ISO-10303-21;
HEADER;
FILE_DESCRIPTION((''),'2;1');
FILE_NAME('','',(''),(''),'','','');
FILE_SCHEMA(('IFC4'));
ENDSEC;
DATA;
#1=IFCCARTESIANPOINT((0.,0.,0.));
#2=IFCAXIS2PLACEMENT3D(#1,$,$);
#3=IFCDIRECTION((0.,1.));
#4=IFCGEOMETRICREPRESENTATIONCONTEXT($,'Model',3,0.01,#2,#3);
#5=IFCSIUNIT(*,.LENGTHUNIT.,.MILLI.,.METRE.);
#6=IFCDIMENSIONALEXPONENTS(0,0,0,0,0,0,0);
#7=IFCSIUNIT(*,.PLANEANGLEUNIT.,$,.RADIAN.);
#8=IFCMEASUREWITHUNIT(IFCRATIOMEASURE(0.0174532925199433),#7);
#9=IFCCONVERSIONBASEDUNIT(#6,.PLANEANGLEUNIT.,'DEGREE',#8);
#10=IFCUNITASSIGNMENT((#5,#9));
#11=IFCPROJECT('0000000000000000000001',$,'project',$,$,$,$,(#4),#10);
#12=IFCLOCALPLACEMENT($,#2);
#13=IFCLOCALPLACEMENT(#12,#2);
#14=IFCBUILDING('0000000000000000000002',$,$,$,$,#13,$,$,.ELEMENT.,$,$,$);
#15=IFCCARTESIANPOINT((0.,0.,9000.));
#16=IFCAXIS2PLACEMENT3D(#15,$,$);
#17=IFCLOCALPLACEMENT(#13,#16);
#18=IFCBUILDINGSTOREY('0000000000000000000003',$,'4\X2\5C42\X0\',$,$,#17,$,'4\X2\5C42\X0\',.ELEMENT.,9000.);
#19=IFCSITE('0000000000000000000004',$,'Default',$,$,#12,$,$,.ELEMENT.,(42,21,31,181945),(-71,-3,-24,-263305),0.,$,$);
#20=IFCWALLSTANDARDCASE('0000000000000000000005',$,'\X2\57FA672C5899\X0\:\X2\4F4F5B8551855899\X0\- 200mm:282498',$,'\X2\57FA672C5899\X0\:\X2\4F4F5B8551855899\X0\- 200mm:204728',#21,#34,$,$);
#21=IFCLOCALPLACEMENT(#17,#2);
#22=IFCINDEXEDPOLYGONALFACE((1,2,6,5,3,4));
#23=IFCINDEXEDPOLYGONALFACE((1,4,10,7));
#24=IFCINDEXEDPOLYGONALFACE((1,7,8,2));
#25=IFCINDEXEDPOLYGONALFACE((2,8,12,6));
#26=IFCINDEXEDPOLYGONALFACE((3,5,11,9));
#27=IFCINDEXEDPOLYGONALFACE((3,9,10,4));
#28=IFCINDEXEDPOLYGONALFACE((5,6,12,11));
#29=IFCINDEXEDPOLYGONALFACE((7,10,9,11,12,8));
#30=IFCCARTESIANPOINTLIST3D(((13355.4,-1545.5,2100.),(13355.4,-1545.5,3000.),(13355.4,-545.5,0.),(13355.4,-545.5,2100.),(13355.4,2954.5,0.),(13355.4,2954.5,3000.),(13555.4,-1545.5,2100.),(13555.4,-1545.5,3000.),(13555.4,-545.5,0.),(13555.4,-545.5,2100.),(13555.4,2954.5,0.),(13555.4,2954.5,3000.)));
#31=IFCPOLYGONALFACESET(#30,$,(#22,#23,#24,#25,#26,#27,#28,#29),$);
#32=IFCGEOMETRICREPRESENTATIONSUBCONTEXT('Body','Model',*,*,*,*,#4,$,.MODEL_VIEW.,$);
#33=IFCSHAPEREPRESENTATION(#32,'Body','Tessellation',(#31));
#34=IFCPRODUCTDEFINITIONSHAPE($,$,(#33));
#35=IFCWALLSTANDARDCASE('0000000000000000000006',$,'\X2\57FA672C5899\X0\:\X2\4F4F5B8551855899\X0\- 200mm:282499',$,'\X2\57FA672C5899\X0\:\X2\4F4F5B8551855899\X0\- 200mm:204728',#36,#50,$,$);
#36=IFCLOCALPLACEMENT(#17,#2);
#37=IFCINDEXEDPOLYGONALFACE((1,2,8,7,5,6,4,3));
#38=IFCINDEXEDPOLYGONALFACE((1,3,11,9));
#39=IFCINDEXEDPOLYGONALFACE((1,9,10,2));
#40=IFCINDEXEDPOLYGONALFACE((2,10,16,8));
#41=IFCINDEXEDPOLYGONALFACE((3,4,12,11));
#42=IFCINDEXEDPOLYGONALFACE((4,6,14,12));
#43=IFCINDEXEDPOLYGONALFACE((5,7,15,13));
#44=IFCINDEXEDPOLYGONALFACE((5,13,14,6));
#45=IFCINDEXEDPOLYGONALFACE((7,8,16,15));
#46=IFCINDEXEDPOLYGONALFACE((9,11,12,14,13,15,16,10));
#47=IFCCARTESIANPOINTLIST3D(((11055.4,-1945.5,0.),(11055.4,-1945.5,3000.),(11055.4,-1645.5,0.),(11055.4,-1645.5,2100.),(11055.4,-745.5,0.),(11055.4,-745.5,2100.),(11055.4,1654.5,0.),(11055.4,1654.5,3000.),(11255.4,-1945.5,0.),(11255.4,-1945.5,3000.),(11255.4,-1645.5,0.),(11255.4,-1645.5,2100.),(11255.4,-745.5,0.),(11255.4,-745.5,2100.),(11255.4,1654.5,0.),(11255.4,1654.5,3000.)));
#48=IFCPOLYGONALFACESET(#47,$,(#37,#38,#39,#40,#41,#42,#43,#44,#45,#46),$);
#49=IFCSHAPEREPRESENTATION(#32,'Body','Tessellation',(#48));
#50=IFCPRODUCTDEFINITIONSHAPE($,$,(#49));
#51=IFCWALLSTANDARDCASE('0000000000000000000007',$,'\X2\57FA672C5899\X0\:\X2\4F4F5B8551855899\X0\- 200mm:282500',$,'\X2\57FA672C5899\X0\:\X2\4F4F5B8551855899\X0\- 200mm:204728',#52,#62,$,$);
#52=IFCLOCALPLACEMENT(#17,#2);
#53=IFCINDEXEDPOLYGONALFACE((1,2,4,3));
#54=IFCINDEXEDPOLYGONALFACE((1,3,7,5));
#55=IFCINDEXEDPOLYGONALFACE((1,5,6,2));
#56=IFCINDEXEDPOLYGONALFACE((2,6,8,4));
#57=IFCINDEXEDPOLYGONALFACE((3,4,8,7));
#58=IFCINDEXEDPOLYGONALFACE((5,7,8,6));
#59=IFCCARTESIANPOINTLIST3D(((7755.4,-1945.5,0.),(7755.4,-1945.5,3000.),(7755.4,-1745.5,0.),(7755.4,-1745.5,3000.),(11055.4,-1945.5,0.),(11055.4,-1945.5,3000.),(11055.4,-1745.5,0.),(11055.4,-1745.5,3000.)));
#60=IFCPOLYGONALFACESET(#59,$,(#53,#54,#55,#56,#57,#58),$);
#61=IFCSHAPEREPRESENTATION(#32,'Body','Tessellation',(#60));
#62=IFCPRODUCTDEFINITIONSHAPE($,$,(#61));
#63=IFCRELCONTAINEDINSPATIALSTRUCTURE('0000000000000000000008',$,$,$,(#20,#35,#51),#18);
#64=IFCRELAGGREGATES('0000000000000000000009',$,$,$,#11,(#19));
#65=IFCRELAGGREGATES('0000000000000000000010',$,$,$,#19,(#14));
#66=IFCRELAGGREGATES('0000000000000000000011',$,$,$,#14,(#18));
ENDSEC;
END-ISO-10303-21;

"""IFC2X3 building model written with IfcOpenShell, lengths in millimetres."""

from ifc_helpers import new_model, entity, si_unit, converted_unit, direction, frame, frame_2d, origin, place, context, subcontext, project, spatial, polyline, rectangle, extrude, clip, bounded_halfspace, element, save


model = new_model("IFC2X3")

# Units and contexts
model_context = context("Model", 3, precision=0.01, world=origin(), true_north=direction((0.0, 1.0)))
body_context = subcontext(model_context, "Body", "Model", "MODEL_VIEW")
ifc_project = project(units=[si_unit("LENGTHUNIT", "METRE", prefix="MILLI"), converted_unit("PLANEANGLEUNIT", "DEGREE", entity("IfcRatioMeasure", 0.0174532925199433), si_unit("PLANEANGLEUNIT", "RADIAN"), dimensions=[0, 0, 0, 0, 0, 0, 0])], contexts=[model_context])

# Site, building, storey
site_placement = place(None, origin())
site = spatial("IfcSite", under=ifc_project, at=site_placement, Name="Default", CompositionType="ELEMENT", RefLatitude=(42, 21, 31, 181945), RefLongitude=(-71, -3, -24, -263305), RefElevation=0.0)
building_placement = place(site_placement, origin())
building = spatial("IfcBuilding", under=site, at=building_placement, CompositionType="ELEMENT")
storey_placement = place(building_placement, frame((0.0, 0.0, 9000.0)))
storey = spatial("IfcBuildingStorey", under=building, at=storey_placement, Name="4层", LongName="4层", CompositionType="ELEMENT", Elevation=9000.0)

# Walls, openings
wall_1_placement = place(storey_placement, frame((13455.4, -1545.5, 0.0), z_axis=(0.0, 0.0, 1.0), x_axis=(0.0, 1.0, 0.0)))
wall_1 = element("IfcWallStandardCase", 1, at=wall_1_placement, inside=storey, Name="基本墙:住宅内墙- 200mm:282498", ObjectType="基本墙:住宅内墙- 200mm:204728", context=body_context, shape_type="Clipping", body=[
    clip(clip(extrude(rectangle(XDim=4500.0, YDim=200.0, at=frame_2d((2250.0, 0.0), x_axis=(-1.0, 0.0))), origin(), (0.0, 0.0, 1.0), 3000.0), bounded_halfspace(frame((0.0, -100.0, 2100.0), z_axis=(1.0, 0.0, 0.0), x_axis=(0.0, 0.0, -1.0)), True, frame((0.0, -100.0, 2100.0), z_axis=(1.0, 0.0, 0.0), x_axis=(0.0, 0.0, -1.0)), polyline([(0.0, 0.0), (0.0, 200.0), (-900.0, 200.0), (-900.0, 0.0), (0.0, 0.0)]))), bounded_halfspace(frame((4500.0, -100.0, 3000.0), z_axis=(-1.0, 0.0, 0.0), x_axis=(0.0, 0.0, -1.0)), True, frame((4500.0, -100.0, 3000.0), z_axis=(-1.0, 0.0, 0.0), x_axis=(0.0, 0.0, -1.0)), polyline([(0.0, 0.0), (0.0, -200.0), (3000.0, -200.0), (3000.0, 0.0), (0.0, 0.0)]))),
])
opening_1_placement = place(wall_1_placement, frame((1000.0, 100.0, 0.0)))
element("IfcOpeningElement", 2, at=opening_1_placement, cuts=wall_1, ObjectType="Opening", context=body_context, shape_type="SweptSolid", body=[
    extrude(rectangle(XDim=2100.0, YDim=1000.0, at=frame_2d((1050.0, 500.0), x_axis=(1.0, 0.0))), frame((0.0, 0.0, 0.0), z_axis=(0.0, -1.0, 0.0), x_axis=(0.0, 0.0, 1.0)), (0.0, 0.0, 1.0), 200.0),
])
wall_2_placement = place(storey_placement, frame((11155.4, 1654.5, 0.0), z_axis=(0.0, 0.0, 1.0), x_axis=(0.0, -1.0, 0.0)))
wall_2 = element("IfcWallStandardCase", 3, at=wall_2_placement, inside=storey, Name="基本墙:住宅内墙- 200mm:282499", ObjectType="基本墙:住宅内墙- 200mm:204728", context=body_context, shape_type="SweptSolid", body=[
    extrude(rectangle(XDim=3600.0, YDim=200.0, at=frame_2d((1800.0, 0.0), x_axis=(-1.0, 0.0))), origin(), (0.0, 0.0, 1.0), 3000.0),
])
opening_2_placement = place(wall_2_placement, frame((3300.0, 100.0, 0.0)))
element("IfcOpeningElement", 4, at=opening_2_placement, cuts=wall_2, ObjectType="Opening", context=body_context, shape_type="SweptSolid", body=[
    extrude(rectangle(XDim=2100.0, YDim=900.0, at=frame_2d((1050.0, 450.0), x_axis=(1.0, 0.0))), frame((0.0, 0.0, 0.0), z_axis=(0.0, -1.0, 0.0), x_axis=(0.0, 0.0, 1.0)), (0.0, 0.0, 1.0), 200.0),
])

# Wall
wall_3_placement = place(storey_placement, frame((11055.4, -1845.5, 0.0), z_axis=(0.0, 0.0, 1.0), x_axis=(-1.0, 0.0, 0.0)))
element("IfcWallStandardCase", 5, at=wall_3_placement, inside=storey, Name="基本墙:住宅内墙- 200mm:282500", ObjectType="基本墙:住宅内墙- 200mm:204728", context=body_context, shape_type="Clipping", body=[
    clip(extrude(rectangle(XDim=3300.0, YDim=200.0, at=frame_2d((1650.0, 0.0), x_axis=(-1.0, 0.0))), origin(), (0.0, 0.0, 1.0), 3000.0), bounded_halfspace(frame((3300.0, -100.0, 3000.0), z_axis=(1.0, 0.0, 0.0), x_axis=(0.0, 0.0, -1.0)), False, frame((3300.0, -100.0, 3000.0), z_axis=(1.0, 0.0, 0.0), x_axis=(0.0, 0.0, -1.0)), polyline([(0.0, 0.0), (3000.0, 0.0), (3000.0, 200.0), (0.0, 200.0), (0.0, 0.0)]))),
])

save(model, "model.ifc")
